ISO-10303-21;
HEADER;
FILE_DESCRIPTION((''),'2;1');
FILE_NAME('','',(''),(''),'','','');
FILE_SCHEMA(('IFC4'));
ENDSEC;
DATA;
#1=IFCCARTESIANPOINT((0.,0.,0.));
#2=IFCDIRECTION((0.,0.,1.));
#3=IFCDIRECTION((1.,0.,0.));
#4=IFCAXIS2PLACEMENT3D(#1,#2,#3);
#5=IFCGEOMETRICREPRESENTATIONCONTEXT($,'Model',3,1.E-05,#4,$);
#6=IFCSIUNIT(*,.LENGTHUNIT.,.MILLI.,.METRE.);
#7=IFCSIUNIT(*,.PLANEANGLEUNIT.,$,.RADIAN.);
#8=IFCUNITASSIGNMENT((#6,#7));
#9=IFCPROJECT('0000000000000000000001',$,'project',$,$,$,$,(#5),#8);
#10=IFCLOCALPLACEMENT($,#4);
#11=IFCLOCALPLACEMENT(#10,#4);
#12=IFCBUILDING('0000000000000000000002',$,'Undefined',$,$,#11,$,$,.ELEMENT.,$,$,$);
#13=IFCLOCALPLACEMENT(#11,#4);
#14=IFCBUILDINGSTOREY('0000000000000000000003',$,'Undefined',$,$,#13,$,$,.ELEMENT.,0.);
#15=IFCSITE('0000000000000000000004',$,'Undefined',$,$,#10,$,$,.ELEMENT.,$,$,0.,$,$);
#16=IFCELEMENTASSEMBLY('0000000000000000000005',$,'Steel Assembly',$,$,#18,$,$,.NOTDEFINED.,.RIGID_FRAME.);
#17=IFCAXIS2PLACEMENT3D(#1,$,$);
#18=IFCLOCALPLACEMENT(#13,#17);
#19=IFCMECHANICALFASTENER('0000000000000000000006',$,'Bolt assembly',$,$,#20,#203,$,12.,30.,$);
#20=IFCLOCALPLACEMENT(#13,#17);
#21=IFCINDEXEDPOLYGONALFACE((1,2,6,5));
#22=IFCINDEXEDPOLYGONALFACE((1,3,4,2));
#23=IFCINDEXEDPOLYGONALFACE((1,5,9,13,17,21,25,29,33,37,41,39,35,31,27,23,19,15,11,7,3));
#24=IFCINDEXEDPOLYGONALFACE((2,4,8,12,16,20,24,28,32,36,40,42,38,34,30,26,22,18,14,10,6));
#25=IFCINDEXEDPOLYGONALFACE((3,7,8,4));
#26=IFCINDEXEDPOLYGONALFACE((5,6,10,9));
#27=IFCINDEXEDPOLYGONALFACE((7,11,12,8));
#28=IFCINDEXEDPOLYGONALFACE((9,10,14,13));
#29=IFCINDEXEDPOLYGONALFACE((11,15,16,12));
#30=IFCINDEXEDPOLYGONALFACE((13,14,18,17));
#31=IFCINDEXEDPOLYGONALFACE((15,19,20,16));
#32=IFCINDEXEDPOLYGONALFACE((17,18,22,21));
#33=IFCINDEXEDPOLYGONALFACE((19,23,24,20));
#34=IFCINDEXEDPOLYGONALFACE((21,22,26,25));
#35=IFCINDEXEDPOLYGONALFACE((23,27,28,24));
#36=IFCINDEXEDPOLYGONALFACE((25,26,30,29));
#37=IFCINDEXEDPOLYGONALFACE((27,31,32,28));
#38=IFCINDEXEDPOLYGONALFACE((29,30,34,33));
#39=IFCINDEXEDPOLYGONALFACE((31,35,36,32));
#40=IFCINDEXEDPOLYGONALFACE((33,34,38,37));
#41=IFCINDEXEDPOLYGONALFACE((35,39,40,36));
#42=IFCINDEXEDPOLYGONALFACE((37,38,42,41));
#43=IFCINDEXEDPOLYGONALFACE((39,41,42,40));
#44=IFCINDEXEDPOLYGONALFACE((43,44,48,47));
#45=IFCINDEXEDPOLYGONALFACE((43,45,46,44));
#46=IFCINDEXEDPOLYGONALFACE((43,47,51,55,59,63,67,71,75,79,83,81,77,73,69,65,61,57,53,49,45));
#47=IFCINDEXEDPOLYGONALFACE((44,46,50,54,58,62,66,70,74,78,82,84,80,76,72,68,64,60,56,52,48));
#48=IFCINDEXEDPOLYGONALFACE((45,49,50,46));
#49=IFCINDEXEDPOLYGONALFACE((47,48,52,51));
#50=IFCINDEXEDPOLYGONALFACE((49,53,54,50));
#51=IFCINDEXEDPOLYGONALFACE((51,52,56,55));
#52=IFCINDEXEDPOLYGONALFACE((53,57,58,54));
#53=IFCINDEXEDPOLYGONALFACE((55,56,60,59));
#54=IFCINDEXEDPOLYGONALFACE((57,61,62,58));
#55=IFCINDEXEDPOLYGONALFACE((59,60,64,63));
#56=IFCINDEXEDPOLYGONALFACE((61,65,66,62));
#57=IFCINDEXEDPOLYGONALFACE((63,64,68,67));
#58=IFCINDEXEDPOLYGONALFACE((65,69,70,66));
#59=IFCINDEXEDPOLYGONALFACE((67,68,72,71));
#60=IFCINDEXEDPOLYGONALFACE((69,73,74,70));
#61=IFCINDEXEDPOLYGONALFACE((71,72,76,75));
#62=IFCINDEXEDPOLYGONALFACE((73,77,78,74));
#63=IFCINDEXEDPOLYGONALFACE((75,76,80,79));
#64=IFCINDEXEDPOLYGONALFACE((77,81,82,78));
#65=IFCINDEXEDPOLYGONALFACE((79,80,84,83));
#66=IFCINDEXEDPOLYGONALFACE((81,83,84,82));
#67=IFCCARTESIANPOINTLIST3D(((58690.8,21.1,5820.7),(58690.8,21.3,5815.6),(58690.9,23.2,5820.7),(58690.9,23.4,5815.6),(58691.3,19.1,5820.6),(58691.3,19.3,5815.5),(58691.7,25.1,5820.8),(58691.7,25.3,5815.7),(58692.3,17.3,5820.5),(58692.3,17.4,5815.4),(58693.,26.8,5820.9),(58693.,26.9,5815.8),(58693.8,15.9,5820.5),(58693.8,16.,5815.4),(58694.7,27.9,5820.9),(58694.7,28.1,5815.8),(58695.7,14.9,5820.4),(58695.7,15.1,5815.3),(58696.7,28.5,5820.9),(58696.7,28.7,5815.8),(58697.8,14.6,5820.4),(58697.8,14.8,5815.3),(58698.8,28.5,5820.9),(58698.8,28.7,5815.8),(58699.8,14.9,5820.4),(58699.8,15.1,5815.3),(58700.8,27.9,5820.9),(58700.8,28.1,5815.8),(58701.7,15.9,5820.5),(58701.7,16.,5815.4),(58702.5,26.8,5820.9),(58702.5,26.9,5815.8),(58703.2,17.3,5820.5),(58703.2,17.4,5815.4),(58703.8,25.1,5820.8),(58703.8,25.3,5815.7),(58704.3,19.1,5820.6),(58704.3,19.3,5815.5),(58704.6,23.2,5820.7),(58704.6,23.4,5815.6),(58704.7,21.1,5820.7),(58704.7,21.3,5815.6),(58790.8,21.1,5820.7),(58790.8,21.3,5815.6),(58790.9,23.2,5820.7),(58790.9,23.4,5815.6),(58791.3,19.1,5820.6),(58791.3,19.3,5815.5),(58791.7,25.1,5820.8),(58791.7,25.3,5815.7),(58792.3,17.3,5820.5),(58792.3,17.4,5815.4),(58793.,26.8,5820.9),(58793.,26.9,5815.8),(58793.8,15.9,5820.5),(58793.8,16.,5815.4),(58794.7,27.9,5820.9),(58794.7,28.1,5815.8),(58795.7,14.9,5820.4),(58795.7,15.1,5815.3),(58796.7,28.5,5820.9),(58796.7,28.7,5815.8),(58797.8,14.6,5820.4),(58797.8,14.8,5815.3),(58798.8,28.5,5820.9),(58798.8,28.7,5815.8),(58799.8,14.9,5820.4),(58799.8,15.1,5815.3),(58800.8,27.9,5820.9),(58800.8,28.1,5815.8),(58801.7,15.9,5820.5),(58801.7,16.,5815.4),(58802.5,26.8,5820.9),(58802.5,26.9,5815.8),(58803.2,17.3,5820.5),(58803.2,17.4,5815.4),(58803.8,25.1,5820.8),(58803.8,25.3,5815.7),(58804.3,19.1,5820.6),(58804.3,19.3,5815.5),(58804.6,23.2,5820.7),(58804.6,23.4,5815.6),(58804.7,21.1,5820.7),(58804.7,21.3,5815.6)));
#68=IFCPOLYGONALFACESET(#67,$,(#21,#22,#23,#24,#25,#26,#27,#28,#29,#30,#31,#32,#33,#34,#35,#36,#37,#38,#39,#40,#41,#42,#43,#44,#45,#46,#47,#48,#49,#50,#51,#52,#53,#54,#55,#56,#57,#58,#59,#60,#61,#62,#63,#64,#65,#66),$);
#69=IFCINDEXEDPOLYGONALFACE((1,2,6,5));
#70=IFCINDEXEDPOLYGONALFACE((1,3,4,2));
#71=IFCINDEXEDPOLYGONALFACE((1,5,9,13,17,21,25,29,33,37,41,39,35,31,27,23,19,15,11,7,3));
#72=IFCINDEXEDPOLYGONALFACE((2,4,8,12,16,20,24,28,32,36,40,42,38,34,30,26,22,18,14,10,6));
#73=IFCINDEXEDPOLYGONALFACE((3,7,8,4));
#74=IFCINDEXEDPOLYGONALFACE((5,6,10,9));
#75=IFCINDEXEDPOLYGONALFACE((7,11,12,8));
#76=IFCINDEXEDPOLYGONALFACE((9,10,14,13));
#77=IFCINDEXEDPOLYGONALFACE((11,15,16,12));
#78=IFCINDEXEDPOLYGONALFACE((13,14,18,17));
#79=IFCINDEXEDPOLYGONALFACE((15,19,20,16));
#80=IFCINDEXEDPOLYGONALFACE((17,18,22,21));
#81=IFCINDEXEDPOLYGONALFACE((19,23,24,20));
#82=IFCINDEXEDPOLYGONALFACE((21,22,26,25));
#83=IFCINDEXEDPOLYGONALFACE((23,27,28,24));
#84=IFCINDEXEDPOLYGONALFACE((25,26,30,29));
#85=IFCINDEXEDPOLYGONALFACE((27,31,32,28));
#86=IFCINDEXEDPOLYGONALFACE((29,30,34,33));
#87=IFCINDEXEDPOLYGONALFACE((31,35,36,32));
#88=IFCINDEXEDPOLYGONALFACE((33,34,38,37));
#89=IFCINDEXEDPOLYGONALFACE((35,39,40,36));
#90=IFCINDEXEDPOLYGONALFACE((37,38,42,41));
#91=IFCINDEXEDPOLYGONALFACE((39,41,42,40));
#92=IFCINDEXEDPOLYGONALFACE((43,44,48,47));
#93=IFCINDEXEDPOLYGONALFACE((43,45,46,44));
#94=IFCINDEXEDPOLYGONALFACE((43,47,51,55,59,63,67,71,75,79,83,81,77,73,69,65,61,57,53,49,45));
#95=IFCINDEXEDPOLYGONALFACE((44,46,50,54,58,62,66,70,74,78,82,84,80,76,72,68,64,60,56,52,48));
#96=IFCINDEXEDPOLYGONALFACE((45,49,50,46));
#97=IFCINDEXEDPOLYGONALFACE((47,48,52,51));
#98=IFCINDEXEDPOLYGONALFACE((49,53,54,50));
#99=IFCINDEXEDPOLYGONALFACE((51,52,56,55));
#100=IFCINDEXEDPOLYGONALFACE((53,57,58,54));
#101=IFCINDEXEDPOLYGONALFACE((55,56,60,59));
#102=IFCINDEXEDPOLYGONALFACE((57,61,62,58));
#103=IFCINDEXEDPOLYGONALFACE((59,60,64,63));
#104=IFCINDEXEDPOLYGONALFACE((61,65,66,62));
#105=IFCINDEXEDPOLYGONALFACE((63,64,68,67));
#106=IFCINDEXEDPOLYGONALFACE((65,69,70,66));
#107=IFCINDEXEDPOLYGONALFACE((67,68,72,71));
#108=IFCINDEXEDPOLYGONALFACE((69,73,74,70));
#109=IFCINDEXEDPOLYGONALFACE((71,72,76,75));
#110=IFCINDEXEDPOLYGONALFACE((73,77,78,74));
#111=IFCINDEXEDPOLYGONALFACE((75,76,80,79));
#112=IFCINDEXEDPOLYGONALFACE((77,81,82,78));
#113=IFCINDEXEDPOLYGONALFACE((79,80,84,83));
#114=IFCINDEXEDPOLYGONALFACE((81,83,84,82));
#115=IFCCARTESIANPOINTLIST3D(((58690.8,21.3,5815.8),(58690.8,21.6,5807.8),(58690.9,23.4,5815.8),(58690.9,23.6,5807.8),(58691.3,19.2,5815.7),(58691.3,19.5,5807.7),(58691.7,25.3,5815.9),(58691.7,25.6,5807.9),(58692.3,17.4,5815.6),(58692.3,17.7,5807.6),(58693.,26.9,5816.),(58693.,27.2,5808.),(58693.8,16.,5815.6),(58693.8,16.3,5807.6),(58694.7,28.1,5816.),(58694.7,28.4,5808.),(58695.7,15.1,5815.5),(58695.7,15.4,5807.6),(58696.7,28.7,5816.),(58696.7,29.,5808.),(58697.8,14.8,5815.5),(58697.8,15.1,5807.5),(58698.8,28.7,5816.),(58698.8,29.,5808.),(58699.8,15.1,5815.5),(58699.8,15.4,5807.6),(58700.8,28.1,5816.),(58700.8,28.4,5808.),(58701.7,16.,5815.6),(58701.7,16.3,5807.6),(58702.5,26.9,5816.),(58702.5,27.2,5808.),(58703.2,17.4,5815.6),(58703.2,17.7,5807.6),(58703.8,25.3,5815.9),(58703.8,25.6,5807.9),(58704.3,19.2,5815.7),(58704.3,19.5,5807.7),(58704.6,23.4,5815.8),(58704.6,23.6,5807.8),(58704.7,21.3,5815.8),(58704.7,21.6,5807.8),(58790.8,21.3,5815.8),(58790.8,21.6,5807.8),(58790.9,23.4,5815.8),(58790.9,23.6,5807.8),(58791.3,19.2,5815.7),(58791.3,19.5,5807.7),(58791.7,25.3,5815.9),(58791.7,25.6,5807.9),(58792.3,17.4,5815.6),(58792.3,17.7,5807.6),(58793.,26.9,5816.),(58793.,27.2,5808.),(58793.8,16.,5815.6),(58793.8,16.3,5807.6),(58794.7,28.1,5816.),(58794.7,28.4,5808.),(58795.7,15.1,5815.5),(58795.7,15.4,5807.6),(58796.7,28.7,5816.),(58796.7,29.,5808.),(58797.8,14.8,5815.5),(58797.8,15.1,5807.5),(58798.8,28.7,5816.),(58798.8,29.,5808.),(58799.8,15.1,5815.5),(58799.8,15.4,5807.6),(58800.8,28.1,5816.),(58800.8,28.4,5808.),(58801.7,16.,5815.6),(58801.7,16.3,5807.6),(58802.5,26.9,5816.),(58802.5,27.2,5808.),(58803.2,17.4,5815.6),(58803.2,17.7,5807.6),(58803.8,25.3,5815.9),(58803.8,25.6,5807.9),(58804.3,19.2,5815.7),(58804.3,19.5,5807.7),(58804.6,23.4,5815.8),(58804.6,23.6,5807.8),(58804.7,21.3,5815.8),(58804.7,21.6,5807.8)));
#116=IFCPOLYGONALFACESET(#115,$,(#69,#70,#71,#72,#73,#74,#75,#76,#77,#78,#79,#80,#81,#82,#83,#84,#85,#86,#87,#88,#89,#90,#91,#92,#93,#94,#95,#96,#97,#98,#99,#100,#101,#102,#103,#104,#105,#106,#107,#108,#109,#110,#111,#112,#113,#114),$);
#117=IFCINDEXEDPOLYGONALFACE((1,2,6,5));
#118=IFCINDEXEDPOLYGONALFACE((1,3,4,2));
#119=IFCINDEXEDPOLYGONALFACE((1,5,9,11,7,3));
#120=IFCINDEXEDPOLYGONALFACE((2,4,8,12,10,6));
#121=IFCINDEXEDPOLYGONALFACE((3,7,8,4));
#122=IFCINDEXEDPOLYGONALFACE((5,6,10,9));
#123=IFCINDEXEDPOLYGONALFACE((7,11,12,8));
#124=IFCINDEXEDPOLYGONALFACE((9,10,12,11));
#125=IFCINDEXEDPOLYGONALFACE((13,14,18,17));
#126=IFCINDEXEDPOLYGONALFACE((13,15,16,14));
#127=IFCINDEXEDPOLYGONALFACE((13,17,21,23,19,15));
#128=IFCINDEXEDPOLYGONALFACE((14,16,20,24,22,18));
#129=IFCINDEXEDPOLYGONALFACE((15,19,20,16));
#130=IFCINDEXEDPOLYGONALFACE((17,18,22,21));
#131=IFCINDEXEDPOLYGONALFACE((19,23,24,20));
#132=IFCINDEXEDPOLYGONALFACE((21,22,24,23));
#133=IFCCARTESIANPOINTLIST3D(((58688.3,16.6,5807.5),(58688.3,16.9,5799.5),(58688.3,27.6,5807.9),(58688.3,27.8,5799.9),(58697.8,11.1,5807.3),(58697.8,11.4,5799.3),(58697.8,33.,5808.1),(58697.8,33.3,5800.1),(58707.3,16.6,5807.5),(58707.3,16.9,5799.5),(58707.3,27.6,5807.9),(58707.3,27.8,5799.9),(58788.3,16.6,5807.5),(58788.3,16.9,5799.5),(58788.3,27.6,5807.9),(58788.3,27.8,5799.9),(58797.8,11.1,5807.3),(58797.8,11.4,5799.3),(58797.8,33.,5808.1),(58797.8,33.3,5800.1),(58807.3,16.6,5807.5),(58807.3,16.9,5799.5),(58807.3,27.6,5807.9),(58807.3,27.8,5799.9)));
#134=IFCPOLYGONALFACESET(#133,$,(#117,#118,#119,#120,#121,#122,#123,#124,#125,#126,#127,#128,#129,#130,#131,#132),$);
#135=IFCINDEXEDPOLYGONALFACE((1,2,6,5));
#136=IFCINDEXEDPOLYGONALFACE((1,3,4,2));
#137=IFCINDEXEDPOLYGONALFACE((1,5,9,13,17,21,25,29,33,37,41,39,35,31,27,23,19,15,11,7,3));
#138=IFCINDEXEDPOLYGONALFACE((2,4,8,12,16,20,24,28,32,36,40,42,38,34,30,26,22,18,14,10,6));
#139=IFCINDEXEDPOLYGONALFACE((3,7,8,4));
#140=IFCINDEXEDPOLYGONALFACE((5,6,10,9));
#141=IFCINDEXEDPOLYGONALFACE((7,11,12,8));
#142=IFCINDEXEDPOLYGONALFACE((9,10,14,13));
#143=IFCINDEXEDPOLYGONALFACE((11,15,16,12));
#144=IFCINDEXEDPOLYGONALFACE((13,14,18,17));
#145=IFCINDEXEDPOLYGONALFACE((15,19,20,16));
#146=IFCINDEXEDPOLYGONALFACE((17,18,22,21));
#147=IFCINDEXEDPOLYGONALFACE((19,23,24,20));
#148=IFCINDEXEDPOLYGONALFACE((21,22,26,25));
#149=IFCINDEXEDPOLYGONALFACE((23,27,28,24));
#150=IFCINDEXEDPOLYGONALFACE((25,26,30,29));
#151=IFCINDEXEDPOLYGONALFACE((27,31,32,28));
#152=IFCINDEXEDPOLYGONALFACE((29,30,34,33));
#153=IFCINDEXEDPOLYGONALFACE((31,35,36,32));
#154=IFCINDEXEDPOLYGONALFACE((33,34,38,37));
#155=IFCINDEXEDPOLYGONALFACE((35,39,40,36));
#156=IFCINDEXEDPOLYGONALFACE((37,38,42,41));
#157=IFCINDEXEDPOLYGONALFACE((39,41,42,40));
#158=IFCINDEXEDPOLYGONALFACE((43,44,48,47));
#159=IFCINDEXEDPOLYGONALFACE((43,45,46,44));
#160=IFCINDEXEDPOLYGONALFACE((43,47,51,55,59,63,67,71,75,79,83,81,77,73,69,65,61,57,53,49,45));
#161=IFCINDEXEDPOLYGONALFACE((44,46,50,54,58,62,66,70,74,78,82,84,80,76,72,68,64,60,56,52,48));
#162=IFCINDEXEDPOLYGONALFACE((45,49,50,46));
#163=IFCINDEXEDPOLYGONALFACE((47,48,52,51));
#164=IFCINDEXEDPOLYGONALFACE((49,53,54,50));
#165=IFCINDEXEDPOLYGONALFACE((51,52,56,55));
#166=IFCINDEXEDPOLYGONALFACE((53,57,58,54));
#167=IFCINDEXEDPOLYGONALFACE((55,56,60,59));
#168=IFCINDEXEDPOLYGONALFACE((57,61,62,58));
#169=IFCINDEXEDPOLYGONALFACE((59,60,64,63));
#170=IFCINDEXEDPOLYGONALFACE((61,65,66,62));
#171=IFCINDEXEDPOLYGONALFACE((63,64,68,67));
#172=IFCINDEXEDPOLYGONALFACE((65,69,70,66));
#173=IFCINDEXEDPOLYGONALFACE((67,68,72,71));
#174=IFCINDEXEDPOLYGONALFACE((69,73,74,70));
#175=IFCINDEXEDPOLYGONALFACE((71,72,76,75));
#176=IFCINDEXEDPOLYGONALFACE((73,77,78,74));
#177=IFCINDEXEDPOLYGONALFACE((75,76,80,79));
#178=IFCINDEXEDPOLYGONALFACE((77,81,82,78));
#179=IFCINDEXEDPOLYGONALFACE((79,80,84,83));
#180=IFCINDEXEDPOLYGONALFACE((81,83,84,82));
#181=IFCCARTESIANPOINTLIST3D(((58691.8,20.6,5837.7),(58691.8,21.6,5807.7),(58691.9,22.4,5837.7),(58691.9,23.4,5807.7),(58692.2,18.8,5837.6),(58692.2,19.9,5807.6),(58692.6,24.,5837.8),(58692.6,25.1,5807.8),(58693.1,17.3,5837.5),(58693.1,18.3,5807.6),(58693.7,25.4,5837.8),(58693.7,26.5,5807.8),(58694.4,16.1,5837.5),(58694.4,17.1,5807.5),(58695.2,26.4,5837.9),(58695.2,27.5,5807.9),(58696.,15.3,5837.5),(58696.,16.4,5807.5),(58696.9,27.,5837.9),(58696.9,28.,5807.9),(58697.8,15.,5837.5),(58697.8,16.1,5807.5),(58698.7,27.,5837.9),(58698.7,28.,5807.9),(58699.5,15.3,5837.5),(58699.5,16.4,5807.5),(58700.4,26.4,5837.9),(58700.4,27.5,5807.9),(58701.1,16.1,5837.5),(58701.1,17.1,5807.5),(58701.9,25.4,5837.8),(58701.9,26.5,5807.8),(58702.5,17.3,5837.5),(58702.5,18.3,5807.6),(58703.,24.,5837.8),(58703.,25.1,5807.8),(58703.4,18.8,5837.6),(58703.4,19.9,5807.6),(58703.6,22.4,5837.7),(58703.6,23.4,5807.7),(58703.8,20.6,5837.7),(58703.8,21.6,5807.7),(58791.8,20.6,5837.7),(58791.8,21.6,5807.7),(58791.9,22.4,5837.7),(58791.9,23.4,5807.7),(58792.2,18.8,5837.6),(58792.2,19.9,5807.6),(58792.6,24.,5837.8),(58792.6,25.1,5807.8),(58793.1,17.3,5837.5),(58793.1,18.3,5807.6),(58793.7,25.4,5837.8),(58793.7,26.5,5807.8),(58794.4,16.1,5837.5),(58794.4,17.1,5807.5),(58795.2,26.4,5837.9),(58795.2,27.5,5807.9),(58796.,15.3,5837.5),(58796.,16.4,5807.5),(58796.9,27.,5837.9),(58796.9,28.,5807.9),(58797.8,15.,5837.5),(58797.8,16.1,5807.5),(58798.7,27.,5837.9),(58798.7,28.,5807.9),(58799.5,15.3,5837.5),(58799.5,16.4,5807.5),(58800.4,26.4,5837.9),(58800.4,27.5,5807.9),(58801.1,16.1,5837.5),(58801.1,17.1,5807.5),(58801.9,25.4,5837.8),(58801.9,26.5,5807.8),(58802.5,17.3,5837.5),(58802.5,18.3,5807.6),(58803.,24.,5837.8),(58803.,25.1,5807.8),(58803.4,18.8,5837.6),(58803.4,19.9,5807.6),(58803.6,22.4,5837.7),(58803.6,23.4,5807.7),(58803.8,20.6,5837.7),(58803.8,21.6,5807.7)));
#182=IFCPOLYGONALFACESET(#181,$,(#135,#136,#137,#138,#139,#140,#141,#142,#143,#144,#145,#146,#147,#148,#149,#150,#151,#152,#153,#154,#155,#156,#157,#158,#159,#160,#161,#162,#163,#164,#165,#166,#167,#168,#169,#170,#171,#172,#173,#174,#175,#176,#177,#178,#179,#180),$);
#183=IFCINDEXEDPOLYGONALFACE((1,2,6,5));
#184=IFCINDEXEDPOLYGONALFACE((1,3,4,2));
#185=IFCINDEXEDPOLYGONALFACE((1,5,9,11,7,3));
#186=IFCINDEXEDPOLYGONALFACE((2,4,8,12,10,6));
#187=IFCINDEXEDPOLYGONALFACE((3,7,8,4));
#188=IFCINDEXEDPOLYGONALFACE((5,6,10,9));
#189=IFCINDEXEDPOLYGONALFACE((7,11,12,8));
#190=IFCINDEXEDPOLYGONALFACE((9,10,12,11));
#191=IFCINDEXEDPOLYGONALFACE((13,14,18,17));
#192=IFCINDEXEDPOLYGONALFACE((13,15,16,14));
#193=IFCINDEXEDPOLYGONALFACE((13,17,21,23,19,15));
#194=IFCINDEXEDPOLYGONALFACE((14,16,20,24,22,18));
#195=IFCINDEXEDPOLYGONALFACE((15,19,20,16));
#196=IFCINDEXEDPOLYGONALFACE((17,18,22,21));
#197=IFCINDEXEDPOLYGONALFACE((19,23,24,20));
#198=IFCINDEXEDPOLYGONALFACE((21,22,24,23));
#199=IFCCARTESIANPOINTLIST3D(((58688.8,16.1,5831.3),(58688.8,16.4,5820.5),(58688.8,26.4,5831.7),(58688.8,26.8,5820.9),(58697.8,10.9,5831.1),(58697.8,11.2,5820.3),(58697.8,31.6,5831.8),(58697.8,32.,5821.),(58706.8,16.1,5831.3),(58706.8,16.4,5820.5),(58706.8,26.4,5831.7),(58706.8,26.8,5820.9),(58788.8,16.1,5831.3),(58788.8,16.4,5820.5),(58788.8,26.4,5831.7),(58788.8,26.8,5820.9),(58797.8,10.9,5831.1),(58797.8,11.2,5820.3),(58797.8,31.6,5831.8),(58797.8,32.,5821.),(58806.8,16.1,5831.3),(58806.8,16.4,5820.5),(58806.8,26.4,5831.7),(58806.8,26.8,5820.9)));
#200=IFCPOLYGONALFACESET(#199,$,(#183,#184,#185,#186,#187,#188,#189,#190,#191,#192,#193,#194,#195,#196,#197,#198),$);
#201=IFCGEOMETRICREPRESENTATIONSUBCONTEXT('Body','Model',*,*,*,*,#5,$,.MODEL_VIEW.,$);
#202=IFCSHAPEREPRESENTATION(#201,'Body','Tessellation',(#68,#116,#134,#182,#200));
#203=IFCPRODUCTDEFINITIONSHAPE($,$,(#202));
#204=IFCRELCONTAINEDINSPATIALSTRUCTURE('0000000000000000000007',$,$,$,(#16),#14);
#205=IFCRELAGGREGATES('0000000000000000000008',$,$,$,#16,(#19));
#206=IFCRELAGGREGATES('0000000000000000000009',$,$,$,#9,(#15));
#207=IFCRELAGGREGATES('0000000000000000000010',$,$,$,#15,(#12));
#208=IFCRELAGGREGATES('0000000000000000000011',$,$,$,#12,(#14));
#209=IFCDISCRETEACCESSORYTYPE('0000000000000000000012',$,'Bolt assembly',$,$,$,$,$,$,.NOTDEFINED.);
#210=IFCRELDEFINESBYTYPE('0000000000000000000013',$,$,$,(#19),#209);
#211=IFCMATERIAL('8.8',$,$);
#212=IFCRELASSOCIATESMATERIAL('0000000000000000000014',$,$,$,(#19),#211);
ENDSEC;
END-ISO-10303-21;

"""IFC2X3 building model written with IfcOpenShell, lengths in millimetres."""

from ifc_helpers import new_model, si_unit, frame, origin_with_axes, origin_2d_with_axis, place, context, subcontext, project, spatial, polyline, circle, outline, extrude, source, transform, mapped, material, type_object, element, aggregate, save


model = new_model("IFC2X3")

# Units and contexts
model_context = context("Model", 3, precision=1e-05, world=origin_with_axes())
body_context = subcontext(model_context, "Body", "Model", "MODEL_VIEW")
ifc_project = project(units=[si_unit("LENGTHUNIT", "METRE", prefix="MILLI"), si_unit("PLANEANGLEUNIT", "RADIAN")], contexts=[model_context])

# Site, building, storey
site_placement = place(None, origin_with_axes())
site = spatial("IfcSite", under=ifc_project, at=site_placement, Name="Undefined", CompositionType="ELEMENT", RefElevation=0.0)
building_placement = place(site_placement, origin_with_axes())
building = spatial("IfcBuilding", under=site, at=building_placement, Name="Undefined", CompositionType="ELEMENT")
storey_placement = place(building_placement, origin_with_axes())
storey = spatial("IfcBuildingStorey", under=building, at=storey_placement, Name="Undefined", CompositionType="ELEMENT", Elevation=0.0)

# Element assembly
assembly_1_placement = place(storey_placement, origin_with_axes())
assembly_1 = element("IfcElementAssembly", 1, at=assembly_1_placement, inside=storey, Name="Steel Assembly", AssemblyPlace="NOTDEFINED", PredefinedType="RIGID_FRAME")

# Shared definitions
discrete_accessory_type_1 = type_object("IfcDiscreteAccessoryType", Name="Bolt assembly")

# Shared definitions
ifc_material_1 = material(Name="8.8")

# Mechanical fastener
shared_shape_1 = source(origin_with_axes(), body_context, "Body", "SweptSolid", [
    extrude(circle(Radius=7.0, at=origin_2d_with_axis()), frame((0.0, -0.1, 0.0), z_axis=(0.0, 1.0, 0.0), x_axis=(1.0, 0.0, 0.0)), (0.0, 0.0, 1.0), 5.1),
    extrude(circle(Radius=7.0, at=origin_2d_with_axis()), frame((0.0, -7.9, 0.0), z_axis=(0.0, 1.0, 0.0), x_axis=(1.0, 0.0, 0.0)), (0.0, 0.0, 1.0), 8.0),
    extrude(outline(polyline([(11.0, 0.0), (5.5, 9.5), (-5.5, 9.5), (-11.0, 0.0), (-5.5, -9.5), (5.5, -9.5), (11.0, 0.0)])), frame((0.0, -16.0, 0.0), z_axis=(0.0, 1.0, 0.0), x_axis=(1.0, 0.0, 0.0)), (0.0, 0.0, 1.0), 8.0),
    extrude(circle(Radius=6.0, at=origin_2d_with_axis()), frame((0.0, -8.0, 0.0), z_axis=(0.0, 1.0, 0.0), x_axis=(1.0, 0.0, 0.0)), (0.0, 0.0, 1.0), 30.0),
    extrude(outline(polyline([(10.4, 0.0), (5.2, 9.0), (-5.2, 9.0), (-10.4, 0.0), (-5.2, -9.0), (5.2, -9.0), (10.4, 0.0)])), frame((0.0, 5.0, 0.0), z_axis=(0.0, 1.0, 0.0), x_axis=(1.0, 0.0, 0.0)), (0.0, 0.0, 1.0), 10.8),
])
mechanical_fastener_1_placement = place(assembly_1_placement, frame((58747.8, 21.8, 5815.7), z_axis=(-1.0, 0.0, 0.0), x_axis=(0.0, -0.999389, -0.034946)))
mechanical_fastener_1 = element("IfcMechanicalFastener", 2, at=mechanical_fastener_1_placement, type_object=discrete_accessory_type_1, material=ifc_material_1, Name="Bolt assembly", NominalDiameter=12.0, NominalLength=30.0, context=body_context, shape_type="MappedRepresentation", body=[
    mapped(shared_shape_1, transform((0.0, 0.0, 50.0))),
    mapped(shared_shape_1, transform((0.0, 0.0, -50.0))),
])

aggregate(assembly_1, [mechanical_fastener_1])

save(model, "model.ifc")
